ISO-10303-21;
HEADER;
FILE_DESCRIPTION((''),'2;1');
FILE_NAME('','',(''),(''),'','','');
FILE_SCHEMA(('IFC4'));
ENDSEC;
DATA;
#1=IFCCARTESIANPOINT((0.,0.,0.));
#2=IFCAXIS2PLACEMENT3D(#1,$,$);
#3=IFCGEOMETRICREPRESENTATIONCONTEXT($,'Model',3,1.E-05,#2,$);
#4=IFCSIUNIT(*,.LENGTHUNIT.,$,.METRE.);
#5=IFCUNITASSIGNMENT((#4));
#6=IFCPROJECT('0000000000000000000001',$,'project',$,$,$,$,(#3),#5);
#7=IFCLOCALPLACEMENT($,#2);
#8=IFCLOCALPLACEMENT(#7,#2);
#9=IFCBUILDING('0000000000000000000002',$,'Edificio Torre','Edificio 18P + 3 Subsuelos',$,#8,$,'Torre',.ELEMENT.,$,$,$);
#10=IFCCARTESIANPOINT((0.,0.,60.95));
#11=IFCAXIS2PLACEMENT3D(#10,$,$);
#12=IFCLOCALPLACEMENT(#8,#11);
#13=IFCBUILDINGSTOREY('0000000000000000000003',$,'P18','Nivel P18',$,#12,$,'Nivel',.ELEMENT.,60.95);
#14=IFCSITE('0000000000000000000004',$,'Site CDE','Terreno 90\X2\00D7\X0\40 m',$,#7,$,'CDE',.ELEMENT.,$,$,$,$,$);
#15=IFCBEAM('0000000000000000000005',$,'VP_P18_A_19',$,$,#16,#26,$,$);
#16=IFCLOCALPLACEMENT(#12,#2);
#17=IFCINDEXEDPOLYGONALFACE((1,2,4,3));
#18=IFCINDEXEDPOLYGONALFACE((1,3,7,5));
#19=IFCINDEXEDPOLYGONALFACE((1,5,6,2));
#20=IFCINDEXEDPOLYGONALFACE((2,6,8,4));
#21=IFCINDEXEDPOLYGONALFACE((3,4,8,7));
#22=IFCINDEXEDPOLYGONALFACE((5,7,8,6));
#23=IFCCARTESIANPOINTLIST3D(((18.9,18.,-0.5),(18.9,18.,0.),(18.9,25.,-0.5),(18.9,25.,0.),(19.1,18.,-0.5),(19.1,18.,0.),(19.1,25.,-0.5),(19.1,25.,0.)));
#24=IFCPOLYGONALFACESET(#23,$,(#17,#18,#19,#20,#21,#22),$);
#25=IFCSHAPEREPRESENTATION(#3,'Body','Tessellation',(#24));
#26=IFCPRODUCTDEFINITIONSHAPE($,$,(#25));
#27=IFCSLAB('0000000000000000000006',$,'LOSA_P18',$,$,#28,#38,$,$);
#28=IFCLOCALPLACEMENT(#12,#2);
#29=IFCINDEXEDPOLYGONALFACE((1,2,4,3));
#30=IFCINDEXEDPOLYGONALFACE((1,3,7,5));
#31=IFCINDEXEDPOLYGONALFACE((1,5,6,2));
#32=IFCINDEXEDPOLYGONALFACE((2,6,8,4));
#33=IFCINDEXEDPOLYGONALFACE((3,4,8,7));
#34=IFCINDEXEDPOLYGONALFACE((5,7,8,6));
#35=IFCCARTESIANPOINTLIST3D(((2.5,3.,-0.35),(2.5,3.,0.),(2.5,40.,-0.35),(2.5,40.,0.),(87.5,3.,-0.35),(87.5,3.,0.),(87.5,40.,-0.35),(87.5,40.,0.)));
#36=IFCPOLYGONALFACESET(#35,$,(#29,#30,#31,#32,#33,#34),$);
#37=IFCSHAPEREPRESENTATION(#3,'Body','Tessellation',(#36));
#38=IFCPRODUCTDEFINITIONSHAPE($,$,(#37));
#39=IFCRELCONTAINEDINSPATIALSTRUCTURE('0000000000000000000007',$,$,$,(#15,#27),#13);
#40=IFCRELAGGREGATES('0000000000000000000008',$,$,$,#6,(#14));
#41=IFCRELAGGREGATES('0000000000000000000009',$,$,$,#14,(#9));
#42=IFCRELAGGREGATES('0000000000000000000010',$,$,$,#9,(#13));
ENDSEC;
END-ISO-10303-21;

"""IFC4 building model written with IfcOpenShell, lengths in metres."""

from ifc_helpers import new_model, si_unit, frame, origin, origin_2d, place, context, project, spatial, rectangle, extrude, element, save


model = new_model("IFC4")

# Units and contexts
model_context = context("Model", 3, precision=1e-05, world=origin())
ifc_project = project(units=[si_unit("LENGTHUNIT", "METRE")], contexts=[model_context])

# Site, building, storey
site_placement = place(None, origin())
site = spatial("IfcSite", under=ifc_project, at=site_placement, Name="Site CDE", Description="Terreno 90×40 m", LongName="CDE", CompositionType="ELEMENT")
building_placement = place(site_placement, origin())
building = spatial("IfcBuilding", under=site, at=building_placement, Name="Edificio Torre", Description="Edificio 18P + 3 Subsuelos", LongName="Torre", CompositionType="ELEMENT")
storey_placement = place(building_placement, frame((0.0, 0.0, 60.95)))
storey = spatial("IfcBuildingStorey", under=building, at=storey_placement, Name="P18", Description="Nivel P18", LongName="Nivel", CompositionType="ELEMENT", Elevation=60.95)

# Beam
beam_1_placement = place(storey_placement, frame((19.0, 21.5, -0.5)))
element("IfcBeam", 1, at=beam_1_placement, inside=storey, Name="VP_P18_A_19", context=model_context, shape_type="SweptSolid", body=[
    extrude(rectangle(XDim=0.2, YDim=7.0, at=origin_2d()), origin(), (0.0, 0.0, 1.0), 0.5),
])

# Slab
slab_placement = place(storey_placement, frame((45.0, 21.5, -0.35)))
element("IfcSlab", 2, at=slab_placement, inside=storey, Name="LOSA_P18", context=model_context, shape_type="SweptSolid", body=[
    extrude(rectangle(XDim=85.0, YDim=37.0, at=origin_2d()), origin(), (0.0, 0.0, 1.0), 0.35),
])

save(model, "model.ifc")
